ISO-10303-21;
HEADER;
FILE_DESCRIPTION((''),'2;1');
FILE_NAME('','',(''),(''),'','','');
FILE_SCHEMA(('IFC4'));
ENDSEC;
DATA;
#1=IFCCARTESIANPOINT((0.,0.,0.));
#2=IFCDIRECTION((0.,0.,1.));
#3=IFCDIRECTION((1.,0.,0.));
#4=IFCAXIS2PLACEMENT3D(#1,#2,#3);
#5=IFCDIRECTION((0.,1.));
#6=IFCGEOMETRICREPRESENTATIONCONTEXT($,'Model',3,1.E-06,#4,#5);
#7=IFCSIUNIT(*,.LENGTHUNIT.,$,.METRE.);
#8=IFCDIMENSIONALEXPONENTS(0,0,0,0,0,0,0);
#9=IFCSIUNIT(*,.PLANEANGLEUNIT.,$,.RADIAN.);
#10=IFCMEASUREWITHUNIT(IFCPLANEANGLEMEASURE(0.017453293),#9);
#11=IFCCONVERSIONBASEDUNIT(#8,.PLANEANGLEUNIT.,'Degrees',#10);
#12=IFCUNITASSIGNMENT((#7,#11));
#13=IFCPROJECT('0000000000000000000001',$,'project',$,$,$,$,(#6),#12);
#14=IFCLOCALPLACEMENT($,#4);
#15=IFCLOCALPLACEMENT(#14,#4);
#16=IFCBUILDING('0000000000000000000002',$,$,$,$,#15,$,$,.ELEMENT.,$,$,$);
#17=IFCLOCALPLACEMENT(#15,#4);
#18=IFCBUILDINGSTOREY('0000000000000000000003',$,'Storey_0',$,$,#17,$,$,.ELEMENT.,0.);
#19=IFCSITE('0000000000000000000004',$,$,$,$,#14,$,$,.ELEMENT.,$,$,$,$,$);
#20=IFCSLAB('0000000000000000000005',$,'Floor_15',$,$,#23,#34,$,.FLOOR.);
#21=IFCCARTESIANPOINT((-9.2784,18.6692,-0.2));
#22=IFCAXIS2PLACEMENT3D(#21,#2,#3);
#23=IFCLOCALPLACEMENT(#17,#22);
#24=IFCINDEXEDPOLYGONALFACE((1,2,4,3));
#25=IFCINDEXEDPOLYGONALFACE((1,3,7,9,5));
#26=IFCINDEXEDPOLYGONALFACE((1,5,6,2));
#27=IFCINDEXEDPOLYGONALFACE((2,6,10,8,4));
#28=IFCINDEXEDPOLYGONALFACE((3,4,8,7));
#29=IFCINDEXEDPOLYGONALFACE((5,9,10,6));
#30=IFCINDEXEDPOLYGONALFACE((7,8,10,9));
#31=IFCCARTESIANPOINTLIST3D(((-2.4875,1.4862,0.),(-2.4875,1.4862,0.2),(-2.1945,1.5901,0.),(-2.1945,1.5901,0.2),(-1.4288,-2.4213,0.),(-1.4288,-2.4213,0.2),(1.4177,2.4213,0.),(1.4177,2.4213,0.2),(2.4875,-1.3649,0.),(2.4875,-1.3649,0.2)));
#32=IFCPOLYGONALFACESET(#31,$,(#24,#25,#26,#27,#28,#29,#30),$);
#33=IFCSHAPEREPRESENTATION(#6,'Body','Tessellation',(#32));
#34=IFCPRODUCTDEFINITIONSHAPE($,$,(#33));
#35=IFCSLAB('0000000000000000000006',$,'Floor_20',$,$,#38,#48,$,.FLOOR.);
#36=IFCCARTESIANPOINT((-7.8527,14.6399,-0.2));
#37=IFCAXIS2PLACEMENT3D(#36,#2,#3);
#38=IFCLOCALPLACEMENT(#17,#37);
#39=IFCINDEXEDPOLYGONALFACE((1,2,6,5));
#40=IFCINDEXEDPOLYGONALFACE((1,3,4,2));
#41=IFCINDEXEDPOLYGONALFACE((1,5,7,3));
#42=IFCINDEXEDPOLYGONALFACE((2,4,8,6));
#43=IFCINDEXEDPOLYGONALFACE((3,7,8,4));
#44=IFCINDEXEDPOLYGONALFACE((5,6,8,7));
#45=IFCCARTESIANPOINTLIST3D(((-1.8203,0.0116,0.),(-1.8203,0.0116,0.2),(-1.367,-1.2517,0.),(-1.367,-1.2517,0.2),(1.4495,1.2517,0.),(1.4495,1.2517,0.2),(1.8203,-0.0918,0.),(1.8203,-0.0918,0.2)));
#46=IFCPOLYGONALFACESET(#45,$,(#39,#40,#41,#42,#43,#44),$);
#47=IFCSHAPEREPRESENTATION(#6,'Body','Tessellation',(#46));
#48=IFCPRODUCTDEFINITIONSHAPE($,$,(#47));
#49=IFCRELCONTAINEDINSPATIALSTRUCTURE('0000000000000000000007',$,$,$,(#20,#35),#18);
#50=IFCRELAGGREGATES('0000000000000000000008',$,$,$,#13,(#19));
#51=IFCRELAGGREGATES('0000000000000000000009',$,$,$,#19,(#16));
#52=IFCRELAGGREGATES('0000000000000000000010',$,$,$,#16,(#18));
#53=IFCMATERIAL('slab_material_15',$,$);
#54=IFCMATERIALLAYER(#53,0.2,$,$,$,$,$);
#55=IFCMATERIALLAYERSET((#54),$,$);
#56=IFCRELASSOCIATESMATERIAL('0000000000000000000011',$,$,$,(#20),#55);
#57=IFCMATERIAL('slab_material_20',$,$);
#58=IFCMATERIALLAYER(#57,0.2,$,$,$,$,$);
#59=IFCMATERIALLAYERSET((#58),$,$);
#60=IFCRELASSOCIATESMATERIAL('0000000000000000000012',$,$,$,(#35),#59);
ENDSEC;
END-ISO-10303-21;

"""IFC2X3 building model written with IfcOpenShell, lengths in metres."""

from ifc_helpers import new_model, entity, si_unit, converted_unit, direction, frame, origin_with_axes, place, context, project, spatial, polyline, outline, extrude, material, layer, layer_set, layer_usage, element, save


model = new_model("IFC2X3")

# Units and contexts
model_context = context("Model", 3, precision=1e-06, world=origin_with_axes(), true_north=direction((0.0, 1.0)))
ifc_project = project(units=[si_unit("LENGTHUNIT", "METRE"), converted_unit("PLANEANGLEUNIT", "Degrees", entity("IfcPlaneAngleMeasure", 0.017453293), si_unit("PLANEANGLEUNIT", "RADIAN"), dimensions=[0, 0, 0, 0, 0, 0, 0])], contexts=[model_context])

# Site, building, storey
site_placement = place(None, origin_with_axes())
site = spatial("IfcSite", under=ifc_project, at=site_placement, CompositionType="ELEMENT")
building_placement = place(site_placement, origin_with_axes())
building = spatial("IfcBuilding", under=site, at=building_placement, CompositionType="ELEMENT")
storey_placement = place(building_placement, origin_with_axes())
storey = spatial("IfcBuildingStorey", under=building, at=storey_placement, Name="Storey_0", CompositionType="ELEMENT", Elevation=0.0)

# Slabs
ifc_material_1 = material(Name="slab_material_15")
ifc_layer_1 = layer(ifc_material_1, 0.2)
ifc_layer_set_1 = layer_set([ifc_layer_1])
ifc_layer_usage_1 = layer_usage(ifc_layer_set_1, "AXIS3", "POSITIVE", 0.0)
slab_1_placement = place(storey_placement, frame((-9.2784, 18.6692, -0.2), z_axis=(0.0, 0.0, 1.0), x_axis=(1.0, 0.0, 0.0)))
element("IfcSlab", 1, at=slab_1_placement, inside=storey, material=ifc_layer_usage_1, Name="Floor_15", PredefinedType="FLOOR", context=model_context, shape_type="SweptSolid", body=[
    extrude(outline(polyline([(2.4875, -1.3649), (-1.4288, -2.4213), (-2.4875, 1.4862), (-2.1945, 1.5901), (1.4177, 2.4213), (2.4875, -1.3649)])), origin_with_axes(), (0.0, 0.0, 1.0), 0.2),
])
ifc_material_2 = material(Name="slab_material_20")
ifc_layer_2 = layer(ifc_material_2, 0.2)
ifc_layer_set_2 = layer_set([ifc_layer_2])
ifc_layer_usage_2 = layer_usage(ifc_layer_set_2, "AXIS3", "POSITIVE", 0.0)
slab_2_placement = place(storey_placement, frame((-7.8527, 14.6399, -0.2), z_axis=(0.0, 0.0, 1.0), x_axis=(1.0, 0.0, 0.0)))
element("IfcSlab", 2, at=slab_2_placement, inside=storey, material=ifc_layer_usage_2, Name="Floor_20", PredefinedType="FLOOR", context=model_context, shape_type="SweptSolid", body=[
    extrude(outline(polyline([(1.8203, -0.0918), (-1.367, -1.2517), (-1.8203, 0.0116), (1.4495, 1.2517), (1.8203, -0.0918)])), origin_with_axes(), (0.0, 0.0, 1.0), 0.2),
])

save(model, "model.ifc")
